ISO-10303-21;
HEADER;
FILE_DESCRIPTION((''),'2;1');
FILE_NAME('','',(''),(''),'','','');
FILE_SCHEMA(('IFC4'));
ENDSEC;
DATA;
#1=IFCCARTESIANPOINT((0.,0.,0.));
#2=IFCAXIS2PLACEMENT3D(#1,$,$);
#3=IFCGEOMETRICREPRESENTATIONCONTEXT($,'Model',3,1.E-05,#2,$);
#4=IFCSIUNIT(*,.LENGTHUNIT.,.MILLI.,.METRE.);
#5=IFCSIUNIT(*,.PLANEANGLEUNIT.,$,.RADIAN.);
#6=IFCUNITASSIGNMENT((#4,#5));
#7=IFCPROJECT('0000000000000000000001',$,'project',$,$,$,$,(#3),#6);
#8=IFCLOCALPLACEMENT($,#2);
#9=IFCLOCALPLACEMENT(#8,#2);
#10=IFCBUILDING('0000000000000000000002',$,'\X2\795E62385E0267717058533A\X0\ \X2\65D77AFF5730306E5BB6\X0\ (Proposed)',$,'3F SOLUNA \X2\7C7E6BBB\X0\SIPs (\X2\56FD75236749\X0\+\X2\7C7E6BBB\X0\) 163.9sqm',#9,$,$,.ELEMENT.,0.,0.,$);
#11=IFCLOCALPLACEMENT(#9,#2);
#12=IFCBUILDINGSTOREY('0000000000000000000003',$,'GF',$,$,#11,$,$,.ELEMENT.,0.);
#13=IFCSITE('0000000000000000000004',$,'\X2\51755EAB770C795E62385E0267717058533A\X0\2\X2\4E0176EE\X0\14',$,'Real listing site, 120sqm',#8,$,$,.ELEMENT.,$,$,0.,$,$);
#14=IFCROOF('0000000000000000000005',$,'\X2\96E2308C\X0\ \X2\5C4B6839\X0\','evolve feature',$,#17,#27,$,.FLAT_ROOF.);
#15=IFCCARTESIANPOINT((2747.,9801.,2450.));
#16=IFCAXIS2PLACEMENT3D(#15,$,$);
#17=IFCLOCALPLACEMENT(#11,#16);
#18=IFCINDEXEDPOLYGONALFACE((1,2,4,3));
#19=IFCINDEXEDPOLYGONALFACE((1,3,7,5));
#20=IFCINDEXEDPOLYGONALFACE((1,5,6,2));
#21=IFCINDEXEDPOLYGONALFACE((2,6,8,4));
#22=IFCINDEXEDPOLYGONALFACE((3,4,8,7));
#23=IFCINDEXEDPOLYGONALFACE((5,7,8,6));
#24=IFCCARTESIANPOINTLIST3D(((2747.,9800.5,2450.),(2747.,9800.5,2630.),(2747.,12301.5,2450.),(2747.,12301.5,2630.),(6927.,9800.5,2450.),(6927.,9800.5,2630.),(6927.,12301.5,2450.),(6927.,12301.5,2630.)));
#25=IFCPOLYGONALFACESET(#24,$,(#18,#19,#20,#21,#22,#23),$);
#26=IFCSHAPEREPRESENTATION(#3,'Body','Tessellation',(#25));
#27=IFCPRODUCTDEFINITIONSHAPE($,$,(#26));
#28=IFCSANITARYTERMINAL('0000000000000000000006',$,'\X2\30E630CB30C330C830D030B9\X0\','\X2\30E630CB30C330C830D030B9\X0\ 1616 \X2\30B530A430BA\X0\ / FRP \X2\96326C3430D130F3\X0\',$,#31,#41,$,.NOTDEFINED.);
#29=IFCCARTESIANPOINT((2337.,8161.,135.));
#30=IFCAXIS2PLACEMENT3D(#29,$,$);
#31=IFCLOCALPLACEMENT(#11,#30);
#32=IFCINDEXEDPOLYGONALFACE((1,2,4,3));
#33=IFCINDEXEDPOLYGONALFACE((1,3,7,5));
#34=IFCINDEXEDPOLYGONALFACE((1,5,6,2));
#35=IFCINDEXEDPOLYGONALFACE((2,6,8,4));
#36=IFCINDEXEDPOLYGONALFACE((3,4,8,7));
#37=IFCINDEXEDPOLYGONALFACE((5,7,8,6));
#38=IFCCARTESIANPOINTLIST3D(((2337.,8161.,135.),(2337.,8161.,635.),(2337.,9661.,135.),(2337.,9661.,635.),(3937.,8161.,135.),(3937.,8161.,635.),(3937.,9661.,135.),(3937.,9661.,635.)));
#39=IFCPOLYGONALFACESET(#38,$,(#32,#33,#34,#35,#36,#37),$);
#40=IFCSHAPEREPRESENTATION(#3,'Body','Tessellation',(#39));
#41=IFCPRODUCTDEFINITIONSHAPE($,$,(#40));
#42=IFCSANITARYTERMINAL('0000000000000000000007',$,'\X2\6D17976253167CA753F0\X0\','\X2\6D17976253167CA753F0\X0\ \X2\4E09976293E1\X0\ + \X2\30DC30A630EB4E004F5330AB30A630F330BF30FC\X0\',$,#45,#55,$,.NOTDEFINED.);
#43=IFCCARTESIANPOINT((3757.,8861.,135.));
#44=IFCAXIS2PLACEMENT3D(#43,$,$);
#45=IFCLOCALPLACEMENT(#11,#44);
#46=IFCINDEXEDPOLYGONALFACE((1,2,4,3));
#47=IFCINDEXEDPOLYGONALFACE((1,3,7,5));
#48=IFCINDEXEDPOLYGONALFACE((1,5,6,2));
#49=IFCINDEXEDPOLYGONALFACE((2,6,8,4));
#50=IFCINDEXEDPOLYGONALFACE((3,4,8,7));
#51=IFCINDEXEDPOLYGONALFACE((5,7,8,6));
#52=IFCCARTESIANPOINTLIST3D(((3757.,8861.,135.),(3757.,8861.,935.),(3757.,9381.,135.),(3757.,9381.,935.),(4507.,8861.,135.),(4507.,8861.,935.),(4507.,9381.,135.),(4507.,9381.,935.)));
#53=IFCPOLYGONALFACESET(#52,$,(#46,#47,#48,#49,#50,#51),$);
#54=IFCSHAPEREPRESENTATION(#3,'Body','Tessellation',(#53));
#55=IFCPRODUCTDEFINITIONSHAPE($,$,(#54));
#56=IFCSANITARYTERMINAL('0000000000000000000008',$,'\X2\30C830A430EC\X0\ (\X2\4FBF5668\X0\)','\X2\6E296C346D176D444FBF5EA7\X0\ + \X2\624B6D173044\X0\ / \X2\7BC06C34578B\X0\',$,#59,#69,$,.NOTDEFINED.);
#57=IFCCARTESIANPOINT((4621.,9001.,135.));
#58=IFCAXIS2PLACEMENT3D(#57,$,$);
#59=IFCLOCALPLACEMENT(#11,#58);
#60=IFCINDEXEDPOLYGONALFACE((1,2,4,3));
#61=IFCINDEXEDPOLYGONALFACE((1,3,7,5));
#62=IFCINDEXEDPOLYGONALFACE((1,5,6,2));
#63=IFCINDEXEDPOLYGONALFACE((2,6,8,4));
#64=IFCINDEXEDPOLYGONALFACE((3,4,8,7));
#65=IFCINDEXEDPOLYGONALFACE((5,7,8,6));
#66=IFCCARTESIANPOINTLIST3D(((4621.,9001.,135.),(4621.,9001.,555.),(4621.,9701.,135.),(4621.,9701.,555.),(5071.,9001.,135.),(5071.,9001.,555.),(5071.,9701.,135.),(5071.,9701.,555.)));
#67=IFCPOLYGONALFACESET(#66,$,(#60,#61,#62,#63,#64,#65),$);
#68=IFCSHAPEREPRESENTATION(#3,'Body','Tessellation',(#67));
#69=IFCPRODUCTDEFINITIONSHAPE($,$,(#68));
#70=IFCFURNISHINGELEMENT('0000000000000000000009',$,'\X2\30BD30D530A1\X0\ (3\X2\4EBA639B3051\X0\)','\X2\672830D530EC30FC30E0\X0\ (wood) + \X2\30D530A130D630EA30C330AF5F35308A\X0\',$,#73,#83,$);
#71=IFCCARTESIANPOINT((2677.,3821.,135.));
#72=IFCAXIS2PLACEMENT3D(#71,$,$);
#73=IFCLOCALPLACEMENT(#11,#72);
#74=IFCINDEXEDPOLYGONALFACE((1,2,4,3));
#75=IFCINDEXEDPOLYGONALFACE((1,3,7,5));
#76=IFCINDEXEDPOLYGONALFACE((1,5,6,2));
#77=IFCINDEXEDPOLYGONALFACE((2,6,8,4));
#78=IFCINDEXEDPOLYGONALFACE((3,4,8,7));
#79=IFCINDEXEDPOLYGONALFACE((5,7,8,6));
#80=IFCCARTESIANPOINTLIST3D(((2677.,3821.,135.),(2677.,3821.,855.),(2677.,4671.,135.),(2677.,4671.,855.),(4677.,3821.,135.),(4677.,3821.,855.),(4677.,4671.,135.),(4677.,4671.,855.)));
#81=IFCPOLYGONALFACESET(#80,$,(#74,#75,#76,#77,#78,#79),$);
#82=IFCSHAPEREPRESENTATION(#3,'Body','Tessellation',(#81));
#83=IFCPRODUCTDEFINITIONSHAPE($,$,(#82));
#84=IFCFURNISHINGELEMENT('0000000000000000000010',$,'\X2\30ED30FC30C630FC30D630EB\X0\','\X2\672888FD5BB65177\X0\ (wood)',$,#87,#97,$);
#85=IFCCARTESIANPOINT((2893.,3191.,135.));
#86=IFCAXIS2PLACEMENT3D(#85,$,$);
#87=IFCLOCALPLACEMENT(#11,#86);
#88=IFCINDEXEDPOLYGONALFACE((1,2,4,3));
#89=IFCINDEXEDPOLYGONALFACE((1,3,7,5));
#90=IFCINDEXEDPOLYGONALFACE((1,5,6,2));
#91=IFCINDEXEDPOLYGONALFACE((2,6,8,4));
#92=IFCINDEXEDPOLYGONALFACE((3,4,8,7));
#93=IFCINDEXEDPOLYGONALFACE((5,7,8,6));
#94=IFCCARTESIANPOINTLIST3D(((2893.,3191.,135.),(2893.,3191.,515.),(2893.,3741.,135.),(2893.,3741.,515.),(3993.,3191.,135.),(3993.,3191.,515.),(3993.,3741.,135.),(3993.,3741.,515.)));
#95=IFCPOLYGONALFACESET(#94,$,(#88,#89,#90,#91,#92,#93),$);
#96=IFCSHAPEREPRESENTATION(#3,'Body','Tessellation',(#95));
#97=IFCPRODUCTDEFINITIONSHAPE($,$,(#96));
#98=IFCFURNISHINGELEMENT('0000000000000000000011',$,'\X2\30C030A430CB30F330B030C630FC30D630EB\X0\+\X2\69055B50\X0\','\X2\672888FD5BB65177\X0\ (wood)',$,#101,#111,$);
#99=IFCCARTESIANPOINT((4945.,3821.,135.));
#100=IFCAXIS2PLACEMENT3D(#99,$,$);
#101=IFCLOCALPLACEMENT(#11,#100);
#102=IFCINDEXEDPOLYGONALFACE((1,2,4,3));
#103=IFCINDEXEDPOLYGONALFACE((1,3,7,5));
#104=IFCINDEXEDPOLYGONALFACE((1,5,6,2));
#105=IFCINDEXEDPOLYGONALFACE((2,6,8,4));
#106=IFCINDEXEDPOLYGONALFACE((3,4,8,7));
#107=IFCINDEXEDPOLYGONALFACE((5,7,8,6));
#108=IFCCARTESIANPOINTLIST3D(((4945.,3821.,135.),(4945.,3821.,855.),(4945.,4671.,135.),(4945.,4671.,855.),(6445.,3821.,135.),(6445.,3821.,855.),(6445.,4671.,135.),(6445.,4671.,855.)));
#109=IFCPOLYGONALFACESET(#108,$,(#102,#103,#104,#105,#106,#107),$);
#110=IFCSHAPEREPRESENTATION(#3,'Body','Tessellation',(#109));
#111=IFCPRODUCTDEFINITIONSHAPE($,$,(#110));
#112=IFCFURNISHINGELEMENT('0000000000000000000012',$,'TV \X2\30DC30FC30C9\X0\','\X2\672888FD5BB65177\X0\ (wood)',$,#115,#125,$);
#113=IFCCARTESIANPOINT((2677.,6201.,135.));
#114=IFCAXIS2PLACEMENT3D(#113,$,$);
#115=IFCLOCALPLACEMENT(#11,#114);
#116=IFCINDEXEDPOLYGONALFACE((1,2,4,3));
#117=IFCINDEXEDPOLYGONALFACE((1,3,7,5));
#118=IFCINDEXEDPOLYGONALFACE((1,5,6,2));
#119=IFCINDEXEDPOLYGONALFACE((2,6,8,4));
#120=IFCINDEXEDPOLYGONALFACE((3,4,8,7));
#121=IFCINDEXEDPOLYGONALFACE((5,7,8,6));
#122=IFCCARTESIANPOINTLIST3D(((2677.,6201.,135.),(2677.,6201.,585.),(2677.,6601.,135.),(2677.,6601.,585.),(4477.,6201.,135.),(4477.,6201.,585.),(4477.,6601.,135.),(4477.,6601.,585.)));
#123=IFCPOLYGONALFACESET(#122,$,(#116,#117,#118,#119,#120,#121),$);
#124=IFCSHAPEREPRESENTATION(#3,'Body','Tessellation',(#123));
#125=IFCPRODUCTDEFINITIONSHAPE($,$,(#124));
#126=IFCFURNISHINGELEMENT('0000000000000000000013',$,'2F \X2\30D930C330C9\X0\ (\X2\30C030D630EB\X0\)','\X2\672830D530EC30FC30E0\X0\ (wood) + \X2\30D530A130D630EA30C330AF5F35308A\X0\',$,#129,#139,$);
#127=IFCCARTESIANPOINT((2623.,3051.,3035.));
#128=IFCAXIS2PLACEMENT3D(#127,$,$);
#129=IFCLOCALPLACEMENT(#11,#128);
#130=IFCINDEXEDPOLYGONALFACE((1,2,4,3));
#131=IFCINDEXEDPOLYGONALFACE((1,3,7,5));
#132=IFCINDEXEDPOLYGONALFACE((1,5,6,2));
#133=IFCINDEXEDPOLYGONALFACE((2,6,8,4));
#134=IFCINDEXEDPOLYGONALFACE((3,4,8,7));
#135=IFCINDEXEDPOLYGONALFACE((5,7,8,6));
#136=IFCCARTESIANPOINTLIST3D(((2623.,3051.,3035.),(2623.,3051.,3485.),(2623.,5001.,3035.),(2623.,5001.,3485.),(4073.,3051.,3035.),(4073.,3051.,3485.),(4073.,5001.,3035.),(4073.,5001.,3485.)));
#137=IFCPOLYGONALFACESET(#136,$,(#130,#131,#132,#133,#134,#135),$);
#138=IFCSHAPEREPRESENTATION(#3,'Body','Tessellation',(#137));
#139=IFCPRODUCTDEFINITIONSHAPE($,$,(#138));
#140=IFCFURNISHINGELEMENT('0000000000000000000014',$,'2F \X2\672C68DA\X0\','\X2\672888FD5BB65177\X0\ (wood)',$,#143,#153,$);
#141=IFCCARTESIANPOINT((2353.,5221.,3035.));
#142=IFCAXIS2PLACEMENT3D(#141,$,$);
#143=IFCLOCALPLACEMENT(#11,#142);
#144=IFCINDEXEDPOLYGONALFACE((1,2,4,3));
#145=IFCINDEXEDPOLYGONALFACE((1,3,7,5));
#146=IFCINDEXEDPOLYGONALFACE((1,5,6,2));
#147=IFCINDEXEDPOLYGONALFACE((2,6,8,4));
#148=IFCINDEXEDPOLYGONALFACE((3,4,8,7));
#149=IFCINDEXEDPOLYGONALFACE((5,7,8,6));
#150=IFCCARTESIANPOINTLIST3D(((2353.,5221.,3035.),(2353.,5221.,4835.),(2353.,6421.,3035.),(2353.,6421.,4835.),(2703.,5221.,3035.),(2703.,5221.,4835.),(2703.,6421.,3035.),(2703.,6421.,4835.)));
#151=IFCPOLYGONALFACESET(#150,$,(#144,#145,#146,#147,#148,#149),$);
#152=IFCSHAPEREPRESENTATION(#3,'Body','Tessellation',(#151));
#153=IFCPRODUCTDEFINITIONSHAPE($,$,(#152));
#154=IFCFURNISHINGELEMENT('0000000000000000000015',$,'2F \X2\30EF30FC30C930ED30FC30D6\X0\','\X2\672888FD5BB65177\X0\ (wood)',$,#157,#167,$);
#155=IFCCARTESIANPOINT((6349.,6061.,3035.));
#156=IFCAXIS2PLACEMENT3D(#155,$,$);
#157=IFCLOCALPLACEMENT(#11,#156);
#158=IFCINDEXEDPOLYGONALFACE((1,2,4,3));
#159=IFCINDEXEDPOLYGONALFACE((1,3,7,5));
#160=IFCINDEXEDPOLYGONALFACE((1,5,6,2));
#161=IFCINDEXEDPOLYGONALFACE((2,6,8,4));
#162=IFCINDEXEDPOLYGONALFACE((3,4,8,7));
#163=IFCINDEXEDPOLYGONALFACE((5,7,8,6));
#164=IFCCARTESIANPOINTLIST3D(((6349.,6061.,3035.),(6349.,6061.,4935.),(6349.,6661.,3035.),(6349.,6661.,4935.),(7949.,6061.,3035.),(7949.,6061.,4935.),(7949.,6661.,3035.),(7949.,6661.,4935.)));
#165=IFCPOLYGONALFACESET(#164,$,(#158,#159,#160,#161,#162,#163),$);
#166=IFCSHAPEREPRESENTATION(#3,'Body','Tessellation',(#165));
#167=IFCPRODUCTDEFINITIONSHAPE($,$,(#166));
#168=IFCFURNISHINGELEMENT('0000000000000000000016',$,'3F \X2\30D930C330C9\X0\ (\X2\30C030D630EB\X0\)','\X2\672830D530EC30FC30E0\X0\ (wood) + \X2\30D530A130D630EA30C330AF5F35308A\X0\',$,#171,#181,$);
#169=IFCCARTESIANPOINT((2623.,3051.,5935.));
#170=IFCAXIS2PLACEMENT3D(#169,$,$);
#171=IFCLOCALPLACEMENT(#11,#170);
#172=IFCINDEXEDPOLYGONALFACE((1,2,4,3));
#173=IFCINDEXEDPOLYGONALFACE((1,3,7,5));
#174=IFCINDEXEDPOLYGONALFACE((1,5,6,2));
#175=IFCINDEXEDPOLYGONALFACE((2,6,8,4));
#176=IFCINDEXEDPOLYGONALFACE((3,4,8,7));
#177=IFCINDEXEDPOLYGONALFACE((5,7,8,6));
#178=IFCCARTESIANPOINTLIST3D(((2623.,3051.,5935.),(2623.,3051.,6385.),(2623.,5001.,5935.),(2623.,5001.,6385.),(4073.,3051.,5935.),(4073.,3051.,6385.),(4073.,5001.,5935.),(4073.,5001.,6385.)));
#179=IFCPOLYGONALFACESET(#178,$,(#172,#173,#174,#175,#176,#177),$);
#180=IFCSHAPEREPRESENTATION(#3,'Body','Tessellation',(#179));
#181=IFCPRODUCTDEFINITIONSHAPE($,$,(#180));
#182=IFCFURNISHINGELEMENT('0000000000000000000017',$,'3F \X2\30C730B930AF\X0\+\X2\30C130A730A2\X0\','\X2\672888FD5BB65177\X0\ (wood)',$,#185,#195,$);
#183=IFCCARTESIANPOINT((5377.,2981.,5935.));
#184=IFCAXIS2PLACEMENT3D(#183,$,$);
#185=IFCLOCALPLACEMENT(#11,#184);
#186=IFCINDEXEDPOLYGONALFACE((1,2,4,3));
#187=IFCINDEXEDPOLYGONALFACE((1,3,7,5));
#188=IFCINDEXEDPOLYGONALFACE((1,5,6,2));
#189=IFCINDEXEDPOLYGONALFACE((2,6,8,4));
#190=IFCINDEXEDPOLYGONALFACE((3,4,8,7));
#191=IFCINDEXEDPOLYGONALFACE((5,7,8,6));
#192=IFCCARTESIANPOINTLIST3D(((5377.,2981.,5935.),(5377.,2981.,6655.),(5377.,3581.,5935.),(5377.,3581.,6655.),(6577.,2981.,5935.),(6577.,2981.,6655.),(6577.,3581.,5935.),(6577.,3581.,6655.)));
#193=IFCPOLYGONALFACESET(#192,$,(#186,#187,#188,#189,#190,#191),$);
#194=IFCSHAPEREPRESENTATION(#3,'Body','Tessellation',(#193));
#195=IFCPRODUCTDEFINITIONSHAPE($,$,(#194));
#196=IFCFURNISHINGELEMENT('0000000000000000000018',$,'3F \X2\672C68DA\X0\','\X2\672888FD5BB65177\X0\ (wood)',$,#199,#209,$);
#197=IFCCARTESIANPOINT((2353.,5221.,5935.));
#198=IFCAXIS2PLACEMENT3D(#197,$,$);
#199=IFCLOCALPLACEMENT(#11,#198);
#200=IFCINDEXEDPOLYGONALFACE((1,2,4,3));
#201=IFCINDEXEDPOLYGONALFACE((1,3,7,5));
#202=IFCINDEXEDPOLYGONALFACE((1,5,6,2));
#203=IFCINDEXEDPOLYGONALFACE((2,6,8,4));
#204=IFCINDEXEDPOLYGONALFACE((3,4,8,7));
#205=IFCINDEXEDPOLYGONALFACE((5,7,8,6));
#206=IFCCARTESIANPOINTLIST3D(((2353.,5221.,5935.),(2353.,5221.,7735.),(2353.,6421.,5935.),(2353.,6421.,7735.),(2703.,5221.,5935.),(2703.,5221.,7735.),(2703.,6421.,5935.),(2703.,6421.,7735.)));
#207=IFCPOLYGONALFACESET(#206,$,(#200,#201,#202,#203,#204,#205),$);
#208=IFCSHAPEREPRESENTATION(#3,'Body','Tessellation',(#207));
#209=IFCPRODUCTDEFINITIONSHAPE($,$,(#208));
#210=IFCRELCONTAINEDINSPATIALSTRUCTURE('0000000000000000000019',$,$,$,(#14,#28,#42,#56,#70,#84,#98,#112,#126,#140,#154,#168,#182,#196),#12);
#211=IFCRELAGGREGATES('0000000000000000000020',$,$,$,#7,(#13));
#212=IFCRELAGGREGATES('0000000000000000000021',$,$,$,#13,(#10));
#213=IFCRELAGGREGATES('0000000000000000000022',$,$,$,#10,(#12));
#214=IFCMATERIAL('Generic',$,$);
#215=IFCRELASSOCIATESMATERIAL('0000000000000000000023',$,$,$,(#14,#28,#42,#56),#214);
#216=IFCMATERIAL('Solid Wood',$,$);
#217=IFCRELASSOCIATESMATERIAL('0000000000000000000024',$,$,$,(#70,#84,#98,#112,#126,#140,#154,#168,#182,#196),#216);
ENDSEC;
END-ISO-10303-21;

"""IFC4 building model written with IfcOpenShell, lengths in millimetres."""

from ifc_helpers import new_model, si_unit, frame, frame_2d, origin, place, context, project, spatial, rectangle, extrude, material, element, save


model = new_model("IFC4")

# Units and contexts
model_context = context("Model", 3, precision=1e-05, world=origin())
ifc_project = project(units=[si_unit("LENGTHUNIT", "METRE", prefix="MILLI"), si_unit("PLANEANGLEUNIT", "RADIAN")], contexts=[model_context])

# Site, building, storey
site_placement = place(None, origin())
site = spatial("IfcSite", under=ifc_project, at=site_placement, Name="兵庫県神戸市東灘区2丁目14", ObjectType="Real listing site, 120sqm", CompositionType="ELEMENT", RefElevation=0.0)
building_placement = place(site_placement, origin())
building = spatial("IfcBuilding", under=site, at=building_placement, Name="神戸市東灘区 旗竿地の家 (Proposed)", ObjectType="3F SOLUNA 籾殻SIPs (国産杉+籾殻) 163.9sqm", CompositionType="ELEMENT", ElevationOfRefHeight=0.0, ElevationOfTerrain=0.0)
storey_placement = place(building_placement, origin())
storey = spatial("IfcBuildingStorey", under=building, at=storey_placement, Name="GF", CompositionType="ELEMENT", Elevation=0.0)

# Shared definitions
ifc_material_1 = material(Name="Generic")

# Shared definitions
ifc_material_2 = material(Name="Solid Wood")

# Roof
roof_placement = place(storey_placement, frame((2747.0, 9801.0, 2450.0)))
element("IfcRoof", 1, at=roof_placement, inside=storey, material=ifc_material_1, Name="離れ 屋根", Description="evolve feature", PredefinedType="FLAT_ROOF", context=model_context, shape_type="SweptSolid", body=[
    extrude(rectangle(XDim=4180.0, YDim=2501.0, at=frame_2d((2090.0, 1250.0))), frame((2747.0, 9801.0, 2450.0)), (0.0, 0.0, 1.0), 180.0),
])

# Sanitary terminals
sanitary_terminal_1_placement = place(storey_placement, frame((2337.0, 8161.0, 135.0)))
element("IfcSanitaryTerminal", 2, at=sanitary_terminal_1_placement, inside=storey, material=ifc_material_1, Name="ユニットバス", Description="ユニットバス 1616 サイズ / FRP 防水パン", PredefinedType="NOTDEFINED", context=model_context, shape_type="SweptSolid", body=[
    extrude(rectangle(XDim=1600.0, YDim=1500.0, at=frame_2d((800.0, 750.0))), frame((2337.0, 8161.0, 135.0)), (0.0, 0.0, 1.0), 500.0),
])
sanitary_terminal_2_placement = place(storey_placement, frame((3757.0, 8861.0, 135.0)))
element("IfcSanitaryTerminal", 3, at=sanitary_terminal_2_placement, inside=storey, material=ifc_material_1, Name="洗面化粧台", Description="洗面化粧台 三面鏡 + ボウル一体カウンター", PredefinedType="NOTDEFINED", context=model_context, shape_type="SweptSolid", body=[
    extrude(rectangle(XDim=750.0, YDim=520.0, at=frame_2d((375.0, 260.0))), frame((3757.0, 8861.0, 135.0)), (0.0, 0.0, 1.0), 800.0),
])
sanitary_terminal_3_placement = place(storey_placement, frame((4621.0, 9001.0, 135.0)))
element("IfcSanitaryTerminal", 4, at=sanitary_terminal_3_placement, inside=storey, material=ifc_material_1, Name="トイレ (便器)", Description="温水洗浄便座 + 手洗い / 節水型", PredefinedType="NOTDEFINED", context=model_context, shape_type="SweptSolid", body=[
    extrude(rectangle(XDim=450.0, YDim=700.0, at=frame_2d((225.0, 350.0))), frame((4621.0, 9001.0, 135.0)), (0.0, 0.0, 1.0), 420.0),
])

# Furnishing elements
furnishing_1_placement = place(storey_placement, frame((2677.0, 3821.0, 135.0)))
element("IfcFurnishingElement", 5, at=furnishing_1_placement, inside=storey, material=ifc_material_2, Name="ソファ (3人掛け)", Description="木フレーム (wood) + ファブリック張り", context=model_context, shape_type="SweptSolid", body=[
    extrude(rectangle(XDim=2000.0, YDim=850.0, at=frame_2d((1000.0, 425.0))), frame((2677.0, 3821.0, 135.0)), (0.0, 0.0, 1.0), 720.0),
])
furnishing_2_placement = place(storey_placement, frame((2893.0, 3191.0, 135.0)))
element("IfcFurnishingElement", 6, at=furnishing_2_placement, inside=storey, material=ifc_material_2, Name="ローテーブル", Description="木製家具 (wood)", context=model_context, shape_type="SweptSolid", body=[
    extrude(rectangle(XDim=1100.0, YDim=550.0, at=frame_2d((550.0, 275.0))), frame((2893.0, 3191.0, 135.0)), (0.0, 0.0, 1.0), 380.0),
])
furnishing_3_placement = place(storey_placement, frame((4945.0, 3821.0, 135.0)))
element("IfcFurnishingElement", 7, at=furnishing_3_placement, inside=storey, material=ifc_material_2, Name="ダイニングテーブル+椅子", Description="木製家具 (wood)", context=model_context, shape_type="SweptSolid", body=[
    extrude(rectangle(XDim=1500.0, YDim=850.0, at=frame_2d((750.0, 425.0))), frame((4945.0, 3821.0, 135.0)), (0.0, 0.0, 1.0), 720.0),
])
furnishing_4_placement = place(storey_placement, frame((2677.0, 6201.0, 135.0)))
element("IfcFurnishingElement", 8, at=furnishing_4_placement, inside=storey, material=ifc_material_2, Name="TV ボード", Description="木製家具 (wood)", context=model_context, shape_type="SweptSolid", body=[
    extrude(rectangle(XDim=1800.0, YDim=400.0, at=frame_2d((900.0, 200.0))), frame((2677.0, 6201.0, 135.0)), (0.0, 0.0, 1.0), 450.0),
])
furnishing_5_placement = place(storey_placement, frame((2623.0, 3051.0, 3035.0)))
element("IfcFurnishingElement", 9, at=furnishing_5_placement, inside=storey, material=ifc_material_2, Name="2F ベッド (ダブル)", Description="木フレーム (wood) + ファブリック張り", context=model_context, shape_type="SweptSolid", body=[
    extrude(rectangle(XDim=1450.0, YDim=1950.0, at=frame_2d((725.0, 975.0))), frame((2623.0, 3051.0, 3035.0)), (0.0, 0.0, 1.0), 450.0),
])
furnishing_6_placement = place(storey_placement, frame((2353.0, 5221.0, 3035.0)))
element("IfcFurnishingElement", 10, at=furnishing_6_placement, inside=storey, material=ifc_material_2, Name="2F 本棚", Description="木製家具 (wood)", context=model_context, shape_type="SweptSolid", body=[
    extrude(rectangle(XDim=350.0, YDim=1200.0, at=frame_2d((175.0, 600.0))), frame((2353.0, 5221.0, 3035.0)), (0.0, 0.0, 1.0), 1800.0),
])
furnishing_7_placement = place(storey_placement, frame((6349.0, 6061.0, 3035.0)))
element("IfcFurnishingElement", 11, at=furnishing_7_placement, inside=storey, material=ifc_material_2, Name="2F ワードローブ", Description="木製家具 (wood)", context=model_context, shape_type="SweptSolid", body=[
    extrude(rectangle(XDim=1600.0, YDim=600.0, at=frame_2d((800.0, 300.0))), frame((6349.0, 6061.0, 3035.0)), (0.0, 0.0, 1.0), 1900.0),
])
furnishing_8_placement = place(storey_placement, frame((2623.0, 3051.0, 5935.0)))
element("IfcFurnishingElement", 12, at=furnishing_8_placement, inside=storey, material=ifc_material_2, Name="3F ベッド (ダブル)", Description="木フレーム (wood) + ファブリック張り", context=model_context, shape_type="SweptSolid", body=[
    extrude(rectangle(XDim=1450.0, YDim=1950.0, at=frame_2d((725.0, 975.0))), frame((2623.0, 3051.0, 5935.0)), (0.0, 0.0, 1.0), 450.0),
])
furnishing_9_placement = place(storey_placement, frame((5377.0, 2981.0, 5935.0)))
element("IfcFurnishingElement", 13, at=furnishing_9_placement, inside=storey, material=ifc_material_2, Name="3F デスク+チェア", Description="木製家具 (wood)", context=model_context, shape_type="SweptSolid", body=[
    extrude(rectangle(XDim=1200.0, YDim=600.0, at=frame_2d((600.0, 300.0))), frame((5377.0, 2981.0, 5935.0)), (0.0, 0.0, 1.0), 720.0),
])
furnishing_10_placement = place(storey_placement, frame((2353.0, 5221.0, 5935.0)))
element("IfcFurnishingElement", 14, at=furnishing_10_placement, inside=storey, material=ifc_material_2, Name="3F 本棚", Description="木製家具 (wood)", context=model_context, shape_type="SweptSolid", body=[
    extrude(rectangle(XDim=350.0, YDim=1200.0, at=frame_2d((175.0, 600.0))), frame((2353.0, 5221.0, 5935.0)), (0.0, 0.0, 1.0), 1800.0),
])

save(model, "model.ifc")
